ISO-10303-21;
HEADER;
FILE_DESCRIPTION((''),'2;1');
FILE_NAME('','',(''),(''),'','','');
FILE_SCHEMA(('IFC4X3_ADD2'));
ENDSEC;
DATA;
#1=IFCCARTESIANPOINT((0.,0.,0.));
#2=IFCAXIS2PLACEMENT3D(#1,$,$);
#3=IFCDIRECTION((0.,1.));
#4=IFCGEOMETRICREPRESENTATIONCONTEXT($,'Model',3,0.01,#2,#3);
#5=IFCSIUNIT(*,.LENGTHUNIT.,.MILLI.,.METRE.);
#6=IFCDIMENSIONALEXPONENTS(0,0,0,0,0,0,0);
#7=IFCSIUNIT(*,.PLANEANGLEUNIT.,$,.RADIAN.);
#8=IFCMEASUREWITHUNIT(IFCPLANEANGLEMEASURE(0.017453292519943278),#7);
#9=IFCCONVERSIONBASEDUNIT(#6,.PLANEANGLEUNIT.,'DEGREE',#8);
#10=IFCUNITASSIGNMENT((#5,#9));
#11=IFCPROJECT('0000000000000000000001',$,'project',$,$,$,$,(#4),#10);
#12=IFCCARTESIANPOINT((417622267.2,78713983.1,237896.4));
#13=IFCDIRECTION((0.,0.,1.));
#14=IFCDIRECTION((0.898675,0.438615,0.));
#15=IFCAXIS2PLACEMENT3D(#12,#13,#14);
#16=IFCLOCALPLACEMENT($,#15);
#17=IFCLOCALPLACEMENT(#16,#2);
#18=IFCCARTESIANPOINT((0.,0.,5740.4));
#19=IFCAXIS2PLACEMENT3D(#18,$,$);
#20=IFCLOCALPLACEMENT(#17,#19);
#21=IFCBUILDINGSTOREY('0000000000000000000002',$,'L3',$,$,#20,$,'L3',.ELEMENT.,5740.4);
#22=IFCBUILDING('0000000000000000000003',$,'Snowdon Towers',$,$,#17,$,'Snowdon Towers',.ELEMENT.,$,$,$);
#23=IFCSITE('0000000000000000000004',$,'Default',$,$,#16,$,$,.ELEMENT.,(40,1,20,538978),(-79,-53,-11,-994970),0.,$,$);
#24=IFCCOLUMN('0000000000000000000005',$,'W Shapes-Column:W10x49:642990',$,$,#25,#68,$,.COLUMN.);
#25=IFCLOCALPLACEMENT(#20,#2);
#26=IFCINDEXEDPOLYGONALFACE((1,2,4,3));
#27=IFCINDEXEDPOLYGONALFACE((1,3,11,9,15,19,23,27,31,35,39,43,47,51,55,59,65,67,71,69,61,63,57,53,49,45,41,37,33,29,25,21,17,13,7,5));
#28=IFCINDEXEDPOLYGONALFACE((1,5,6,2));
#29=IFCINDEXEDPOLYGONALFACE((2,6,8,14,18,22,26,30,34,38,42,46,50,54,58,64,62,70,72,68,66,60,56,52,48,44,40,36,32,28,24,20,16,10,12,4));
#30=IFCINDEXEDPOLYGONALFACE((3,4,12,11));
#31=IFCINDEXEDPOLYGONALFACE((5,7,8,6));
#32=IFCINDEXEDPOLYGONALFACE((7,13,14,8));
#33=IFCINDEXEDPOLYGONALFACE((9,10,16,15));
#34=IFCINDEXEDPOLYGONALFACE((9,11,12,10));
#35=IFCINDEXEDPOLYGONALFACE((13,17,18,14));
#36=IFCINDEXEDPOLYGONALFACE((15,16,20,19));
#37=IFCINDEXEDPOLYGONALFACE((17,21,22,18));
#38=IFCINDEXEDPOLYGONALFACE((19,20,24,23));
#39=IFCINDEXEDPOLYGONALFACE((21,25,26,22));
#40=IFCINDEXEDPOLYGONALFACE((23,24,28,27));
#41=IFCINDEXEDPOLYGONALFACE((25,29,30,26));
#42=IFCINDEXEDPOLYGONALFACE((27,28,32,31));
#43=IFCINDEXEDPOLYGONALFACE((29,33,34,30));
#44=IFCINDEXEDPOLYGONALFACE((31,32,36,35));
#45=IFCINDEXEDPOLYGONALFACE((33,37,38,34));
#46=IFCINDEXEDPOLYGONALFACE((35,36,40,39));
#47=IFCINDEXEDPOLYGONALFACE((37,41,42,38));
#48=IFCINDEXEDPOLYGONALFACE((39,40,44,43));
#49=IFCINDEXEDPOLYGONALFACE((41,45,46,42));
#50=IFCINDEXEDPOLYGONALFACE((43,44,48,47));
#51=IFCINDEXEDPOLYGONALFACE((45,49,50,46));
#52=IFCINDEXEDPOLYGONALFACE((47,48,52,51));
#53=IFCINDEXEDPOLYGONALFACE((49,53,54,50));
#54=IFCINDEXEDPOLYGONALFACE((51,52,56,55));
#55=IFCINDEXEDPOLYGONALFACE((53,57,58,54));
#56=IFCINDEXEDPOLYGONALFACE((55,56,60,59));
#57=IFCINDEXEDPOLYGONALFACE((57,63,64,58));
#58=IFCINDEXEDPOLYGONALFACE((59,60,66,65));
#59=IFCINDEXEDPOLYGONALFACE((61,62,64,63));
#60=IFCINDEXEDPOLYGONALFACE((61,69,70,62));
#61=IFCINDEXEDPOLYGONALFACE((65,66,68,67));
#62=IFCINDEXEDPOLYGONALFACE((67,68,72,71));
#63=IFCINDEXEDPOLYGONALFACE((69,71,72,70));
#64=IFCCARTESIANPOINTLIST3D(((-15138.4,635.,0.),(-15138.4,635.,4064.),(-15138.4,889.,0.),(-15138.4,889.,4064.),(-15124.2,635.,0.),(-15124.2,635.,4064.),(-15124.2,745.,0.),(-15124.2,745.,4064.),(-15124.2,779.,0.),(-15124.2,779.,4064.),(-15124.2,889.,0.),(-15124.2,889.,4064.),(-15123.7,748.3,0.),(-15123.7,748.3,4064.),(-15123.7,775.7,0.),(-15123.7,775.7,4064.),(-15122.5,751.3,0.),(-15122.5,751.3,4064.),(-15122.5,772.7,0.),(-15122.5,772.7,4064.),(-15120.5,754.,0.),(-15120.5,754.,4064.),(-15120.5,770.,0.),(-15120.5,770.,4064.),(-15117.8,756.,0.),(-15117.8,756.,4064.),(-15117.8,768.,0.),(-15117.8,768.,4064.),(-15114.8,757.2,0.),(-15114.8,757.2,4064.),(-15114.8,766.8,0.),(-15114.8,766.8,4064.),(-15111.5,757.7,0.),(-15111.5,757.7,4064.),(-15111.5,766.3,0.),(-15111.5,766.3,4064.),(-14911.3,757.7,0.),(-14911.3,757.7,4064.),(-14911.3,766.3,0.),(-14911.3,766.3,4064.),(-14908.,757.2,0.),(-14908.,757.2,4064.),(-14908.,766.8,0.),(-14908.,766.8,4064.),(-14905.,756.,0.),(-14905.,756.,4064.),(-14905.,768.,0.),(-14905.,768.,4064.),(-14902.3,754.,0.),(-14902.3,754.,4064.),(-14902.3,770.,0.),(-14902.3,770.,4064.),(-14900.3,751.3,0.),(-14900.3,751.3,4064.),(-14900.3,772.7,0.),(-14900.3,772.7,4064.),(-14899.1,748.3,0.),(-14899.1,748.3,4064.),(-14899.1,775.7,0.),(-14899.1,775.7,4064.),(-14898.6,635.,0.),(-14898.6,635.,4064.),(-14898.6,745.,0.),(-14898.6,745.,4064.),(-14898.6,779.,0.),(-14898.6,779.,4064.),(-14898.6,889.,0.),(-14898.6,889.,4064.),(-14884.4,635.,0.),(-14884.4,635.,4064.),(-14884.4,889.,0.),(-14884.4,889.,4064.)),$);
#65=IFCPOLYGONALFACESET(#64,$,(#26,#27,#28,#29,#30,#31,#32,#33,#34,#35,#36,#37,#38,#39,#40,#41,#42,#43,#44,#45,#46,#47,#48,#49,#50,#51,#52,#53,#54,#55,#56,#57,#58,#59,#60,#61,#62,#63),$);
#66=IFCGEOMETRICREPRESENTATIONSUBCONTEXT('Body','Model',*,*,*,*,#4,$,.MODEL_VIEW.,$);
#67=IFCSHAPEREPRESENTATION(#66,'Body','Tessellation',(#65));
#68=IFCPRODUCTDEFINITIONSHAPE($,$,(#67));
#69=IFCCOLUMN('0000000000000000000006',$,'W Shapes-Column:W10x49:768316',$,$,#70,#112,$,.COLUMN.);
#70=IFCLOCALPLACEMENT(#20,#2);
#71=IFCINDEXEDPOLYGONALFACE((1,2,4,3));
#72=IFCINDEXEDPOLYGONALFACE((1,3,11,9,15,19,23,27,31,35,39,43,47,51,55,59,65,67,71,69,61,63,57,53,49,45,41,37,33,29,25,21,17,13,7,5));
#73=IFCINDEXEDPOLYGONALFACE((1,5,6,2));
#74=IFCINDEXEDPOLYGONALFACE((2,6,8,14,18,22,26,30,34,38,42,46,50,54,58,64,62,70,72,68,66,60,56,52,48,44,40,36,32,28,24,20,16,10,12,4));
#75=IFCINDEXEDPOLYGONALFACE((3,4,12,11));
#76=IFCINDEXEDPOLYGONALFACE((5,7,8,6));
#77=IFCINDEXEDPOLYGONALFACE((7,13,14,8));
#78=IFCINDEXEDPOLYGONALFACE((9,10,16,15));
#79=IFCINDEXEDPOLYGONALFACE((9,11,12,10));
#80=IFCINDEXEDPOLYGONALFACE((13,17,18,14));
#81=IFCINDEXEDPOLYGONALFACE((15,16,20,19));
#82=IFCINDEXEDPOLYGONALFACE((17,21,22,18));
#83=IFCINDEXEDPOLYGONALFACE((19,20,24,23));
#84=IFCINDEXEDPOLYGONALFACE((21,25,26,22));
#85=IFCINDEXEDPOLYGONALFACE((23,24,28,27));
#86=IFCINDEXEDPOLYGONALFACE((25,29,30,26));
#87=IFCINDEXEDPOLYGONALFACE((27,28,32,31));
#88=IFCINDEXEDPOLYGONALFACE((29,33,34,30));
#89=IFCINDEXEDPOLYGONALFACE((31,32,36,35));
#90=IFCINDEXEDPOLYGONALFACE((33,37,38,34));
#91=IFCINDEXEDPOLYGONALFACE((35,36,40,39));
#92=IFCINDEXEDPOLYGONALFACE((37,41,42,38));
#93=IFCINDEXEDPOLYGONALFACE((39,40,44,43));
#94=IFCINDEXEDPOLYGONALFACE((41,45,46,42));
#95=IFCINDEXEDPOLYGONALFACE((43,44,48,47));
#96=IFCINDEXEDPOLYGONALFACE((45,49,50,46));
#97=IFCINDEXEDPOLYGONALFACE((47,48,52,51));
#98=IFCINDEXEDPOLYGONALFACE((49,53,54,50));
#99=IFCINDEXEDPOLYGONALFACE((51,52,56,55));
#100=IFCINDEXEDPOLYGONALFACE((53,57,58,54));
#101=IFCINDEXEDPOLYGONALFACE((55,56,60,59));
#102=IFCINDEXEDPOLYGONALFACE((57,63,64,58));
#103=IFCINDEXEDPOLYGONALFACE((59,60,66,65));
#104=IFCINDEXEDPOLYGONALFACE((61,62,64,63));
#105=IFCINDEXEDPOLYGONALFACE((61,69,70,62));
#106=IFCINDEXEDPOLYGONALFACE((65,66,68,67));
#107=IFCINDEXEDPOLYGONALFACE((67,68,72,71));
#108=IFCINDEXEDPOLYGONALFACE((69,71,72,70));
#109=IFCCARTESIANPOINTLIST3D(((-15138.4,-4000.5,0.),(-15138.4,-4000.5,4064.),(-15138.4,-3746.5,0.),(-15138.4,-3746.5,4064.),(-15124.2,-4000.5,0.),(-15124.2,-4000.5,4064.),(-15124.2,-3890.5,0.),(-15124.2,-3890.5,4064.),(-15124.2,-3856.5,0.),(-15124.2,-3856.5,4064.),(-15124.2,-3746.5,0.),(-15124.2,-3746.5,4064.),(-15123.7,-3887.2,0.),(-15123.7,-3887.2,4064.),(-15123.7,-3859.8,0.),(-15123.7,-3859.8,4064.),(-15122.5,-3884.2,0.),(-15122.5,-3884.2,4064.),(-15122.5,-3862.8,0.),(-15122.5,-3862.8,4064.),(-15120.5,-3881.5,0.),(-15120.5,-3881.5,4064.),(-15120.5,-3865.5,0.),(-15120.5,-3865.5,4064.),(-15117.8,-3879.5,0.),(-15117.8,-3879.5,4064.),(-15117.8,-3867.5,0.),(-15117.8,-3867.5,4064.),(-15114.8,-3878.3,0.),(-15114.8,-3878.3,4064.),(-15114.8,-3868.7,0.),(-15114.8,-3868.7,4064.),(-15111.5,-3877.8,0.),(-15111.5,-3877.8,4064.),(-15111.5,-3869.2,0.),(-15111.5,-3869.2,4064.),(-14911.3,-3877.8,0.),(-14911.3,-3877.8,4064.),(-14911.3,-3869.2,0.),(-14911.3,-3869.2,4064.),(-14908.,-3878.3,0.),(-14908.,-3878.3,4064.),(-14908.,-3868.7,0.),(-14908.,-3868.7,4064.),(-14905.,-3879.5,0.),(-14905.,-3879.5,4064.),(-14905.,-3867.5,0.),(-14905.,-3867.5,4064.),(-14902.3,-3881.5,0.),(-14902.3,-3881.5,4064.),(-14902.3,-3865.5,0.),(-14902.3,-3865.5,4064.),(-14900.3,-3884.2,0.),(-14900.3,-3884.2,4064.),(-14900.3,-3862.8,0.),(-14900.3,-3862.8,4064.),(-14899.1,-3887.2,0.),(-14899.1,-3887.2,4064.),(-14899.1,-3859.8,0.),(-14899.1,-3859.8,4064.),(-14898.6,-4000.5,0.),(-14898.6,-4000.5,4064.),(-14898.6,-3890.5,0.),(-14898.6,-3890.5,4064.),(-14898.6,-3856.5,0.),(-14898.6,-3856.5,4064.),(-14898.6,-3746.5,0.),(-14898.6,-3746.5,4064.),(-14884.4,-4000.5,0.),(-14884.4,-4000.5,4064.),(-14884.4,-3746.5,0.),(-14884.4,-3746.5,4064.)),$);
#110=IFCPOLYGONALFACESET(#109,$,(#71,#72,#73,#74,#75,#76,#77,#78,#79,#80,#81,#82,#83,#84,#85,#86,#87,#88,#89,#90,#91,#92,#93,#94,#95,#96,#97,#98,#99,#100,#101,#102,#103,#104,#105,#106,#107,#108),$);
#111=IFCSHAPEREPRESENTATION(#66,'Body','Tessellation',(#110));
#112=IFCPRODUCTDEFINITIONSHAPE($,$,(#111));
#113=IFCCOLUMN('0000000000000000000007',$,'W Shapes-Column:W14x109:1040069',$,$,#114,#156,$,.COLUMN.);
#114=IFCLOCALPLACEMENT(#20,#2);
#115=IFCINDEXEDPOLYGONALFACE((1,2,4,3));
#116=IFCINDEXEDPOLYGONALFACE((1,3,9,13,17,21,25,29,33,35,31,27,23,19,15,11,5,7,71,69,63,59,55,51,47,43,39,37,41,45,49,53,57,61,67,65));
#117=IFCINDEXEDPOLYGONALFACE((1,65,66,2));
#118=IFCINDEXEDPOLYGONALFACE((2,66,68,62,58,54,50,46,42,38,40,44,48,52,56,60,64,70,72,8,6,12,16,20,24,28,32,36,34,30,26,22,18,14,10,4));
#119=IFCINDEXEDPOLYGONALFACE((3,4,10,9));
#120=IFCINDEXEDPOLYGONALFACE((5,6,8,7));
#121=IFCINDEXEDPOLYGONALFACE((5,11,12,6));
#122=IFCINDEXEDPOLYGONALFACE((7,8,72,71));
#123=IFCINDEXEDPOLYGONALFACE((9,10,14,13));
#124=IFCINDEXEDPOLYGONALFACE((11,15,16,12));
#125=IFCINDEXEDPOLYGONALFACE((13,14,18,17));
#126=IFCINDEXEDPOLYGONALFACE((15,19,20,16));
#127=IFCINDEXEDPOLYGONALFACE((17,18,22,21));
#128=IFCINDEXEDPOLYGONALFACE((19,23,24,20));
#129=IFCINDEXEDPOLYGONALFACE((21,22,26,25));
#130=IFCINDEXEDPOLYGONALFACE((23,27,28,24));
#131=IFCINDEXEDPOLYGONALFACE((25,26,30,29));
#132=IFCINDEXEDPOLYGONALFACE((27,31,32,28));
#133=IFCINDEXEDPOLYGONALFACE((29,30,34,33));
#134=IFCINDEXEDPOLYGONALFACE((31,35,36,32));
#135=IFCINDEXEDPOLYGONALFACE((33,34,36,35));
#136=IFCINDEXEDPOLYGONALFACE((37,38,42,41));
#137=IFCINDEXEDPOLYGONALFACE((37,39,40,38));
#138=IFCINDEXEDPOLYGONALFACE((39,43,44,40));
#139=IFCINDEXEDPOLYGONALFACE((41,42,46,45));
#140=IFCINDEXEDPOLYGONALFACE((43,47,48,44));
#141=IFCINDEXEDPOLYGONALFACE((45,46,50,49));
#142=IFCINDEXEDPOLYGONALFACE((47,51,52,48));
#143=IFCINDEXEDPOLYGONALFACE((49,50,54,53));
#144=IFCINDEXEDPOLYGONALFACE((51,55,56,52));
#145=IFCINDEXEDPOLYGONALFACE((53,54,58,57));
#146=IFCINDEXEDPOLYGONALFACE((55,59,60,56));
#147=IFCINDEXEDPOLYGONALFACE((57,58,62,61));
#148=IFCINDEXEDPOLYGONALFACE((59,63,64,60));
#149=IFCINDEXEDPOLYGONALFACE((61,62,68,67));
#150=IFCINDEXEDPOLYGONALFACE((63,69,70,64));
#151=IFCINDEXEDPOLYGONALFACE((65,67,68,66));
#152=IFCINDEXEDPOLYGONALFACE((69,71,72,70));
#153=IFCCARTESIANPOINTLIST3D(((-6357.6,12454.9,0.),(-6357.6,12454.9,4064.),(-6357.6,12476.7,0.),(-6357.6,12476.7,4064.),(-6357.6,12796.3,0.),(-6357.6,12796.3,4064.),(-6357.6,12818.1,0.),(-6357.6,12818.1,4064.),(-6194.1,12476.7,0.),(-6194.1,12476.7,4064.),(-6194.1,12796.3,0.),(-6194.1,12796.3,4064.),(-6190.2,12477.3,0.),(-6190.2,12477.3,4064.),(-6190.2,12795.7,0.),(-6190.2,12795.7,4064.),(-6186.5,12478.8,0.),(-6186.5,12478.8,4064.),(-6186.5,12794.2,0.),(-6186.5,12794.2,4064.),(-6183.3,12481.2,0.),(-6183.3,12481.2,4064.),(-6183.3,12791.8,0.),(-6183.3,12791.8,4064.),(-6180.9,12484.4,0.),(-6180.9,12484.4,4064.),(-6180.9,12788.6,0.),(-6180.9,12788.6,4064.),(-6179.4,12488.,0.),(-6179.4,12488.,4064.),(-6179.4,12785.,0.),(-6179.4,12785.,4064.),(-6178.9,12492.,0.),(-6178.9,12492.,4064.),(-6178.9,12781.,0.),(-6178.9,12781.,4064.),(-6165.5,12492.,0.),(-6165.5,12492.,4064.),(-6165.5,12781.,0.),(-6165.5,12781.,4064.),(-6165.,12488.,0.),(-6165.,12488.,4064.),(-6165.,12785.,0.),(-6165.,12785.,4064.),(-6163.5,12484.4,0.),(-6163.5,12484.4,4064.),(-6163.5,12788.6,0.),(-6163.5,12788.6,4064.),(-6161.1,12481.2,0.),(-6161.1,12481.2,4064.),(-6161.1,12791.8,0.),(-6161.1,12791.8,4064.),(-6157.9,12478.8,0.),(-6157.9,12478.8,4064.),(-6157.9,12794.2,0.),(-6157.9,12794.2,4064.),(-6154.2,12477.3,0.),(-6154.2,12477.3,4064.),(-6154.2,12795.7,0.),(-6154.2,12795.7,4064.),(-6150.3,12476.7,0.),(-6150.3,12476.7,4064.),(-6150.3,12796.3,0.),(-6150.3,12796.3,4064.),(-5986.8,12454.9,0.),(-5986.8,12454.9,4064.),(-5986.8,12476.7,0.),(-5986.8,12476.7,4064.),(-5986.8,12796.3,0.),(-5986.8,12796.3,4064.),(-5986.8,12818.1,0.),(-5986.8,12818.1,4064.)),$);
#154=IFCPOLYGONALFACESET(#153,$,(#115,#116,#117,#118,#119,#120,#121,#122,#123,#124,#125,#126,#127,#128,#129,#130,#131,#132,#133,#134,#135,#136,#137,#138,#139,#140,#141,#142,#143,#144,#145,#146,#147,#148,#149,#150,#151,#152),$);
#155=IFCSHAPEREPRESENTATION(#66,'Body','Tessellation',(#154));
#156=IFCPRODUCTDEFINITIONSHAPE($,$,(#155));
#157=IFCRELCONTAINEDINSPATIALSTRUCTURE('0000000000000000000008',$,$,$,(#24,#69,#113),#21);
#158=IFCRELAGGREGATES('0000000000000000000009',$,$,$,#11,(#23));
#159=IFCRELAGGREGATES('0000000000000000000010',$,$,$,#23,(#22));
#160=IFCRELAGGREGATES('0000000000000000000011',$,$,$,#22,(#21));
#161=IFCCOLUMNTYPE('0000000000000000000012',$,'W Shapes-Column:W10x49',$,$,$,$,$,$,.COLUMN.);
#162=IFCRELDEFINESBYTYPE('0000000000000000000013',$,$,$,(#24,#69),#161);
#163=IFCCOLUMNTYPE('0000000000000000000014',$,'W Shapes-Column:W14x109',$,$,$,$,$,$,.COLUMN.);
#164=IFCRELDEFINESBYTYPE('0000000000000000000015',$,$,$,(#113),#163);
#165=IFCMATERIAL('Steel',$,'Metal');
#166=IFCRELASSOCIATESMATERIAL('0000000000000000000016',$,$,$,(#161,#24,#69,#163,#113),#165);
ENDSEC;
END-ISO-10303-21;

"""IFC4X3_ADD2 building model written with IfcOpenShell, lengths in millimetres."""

from ifc_helpers import new_model, entity, si_unit, converted_unit, direction, frame, frame_2d, origin, place, context, subcontext, project, spatial, i_section, extrude, source, transform, mapped, material, material_profile, profile_set, profile_usage, type_object, type_shapes, element, save


model = new_model("IFC4X3_ADD2")

# Units and contexts
model_context = context("Model", 3, precision=0.01, world=origin(), true_north=direction((0.0, 1.0)))
body_context = subcontext(model_context, "Body", "Model", "MODEL_VIEW")
ifc_project = project(units=[si_unit("LENGTHUNIT", "METRE", prefix="MILLI"), converted_unit("PLANEANGLEUNIT", "DEGREE", entity("IfcPlaneAngleMeasure", 0.017453292519943278), si_unit("PLANEANGLEUNIT", "RADIAN"), dimensions=[0, 0, 0, 0, 0, 0, 0])], contexts=[model_context])

# Site, building, storey
site_placement = place(None, frame((417622267.2, 78713983.1, 237896.4), z_axis=(0.0, 0.0, 1.0), x_axis=(0.898675, 0.438615, 0.0)))
site = spatial("IfcSite", under=ifc_project, at=site_placement, Name="Default", CompositionType="ELEMENT", RefLatitude=(40, 1, 20, 538978), RefLongitude=(-79, -53, -11, -994970), RefElevation=0.0)
building_placement = place(site_placement, origin())
building = spatial("IfcBuilding", under=site, at=building_placement, Name="Snowdon Towers", LongName="Snowdon Towers", CompositionType="ELEMENT")
storey_placement = place(building_placement, frame((0.0, 0.0, 5740.4)))
storey = spatial("IfcBuildingStorey", under=building, at=storey_placement, Name="L3", LongName="L3", CompositionType="ELEMENT", Elevation=5740.4)

# Columns
ifc_material_1 = material(Name="Steel", Category="Metal")
ifc_material_profile_1 = material_profile(ifc_material_1, i_section(OverallWidth=254.0, OverallDepth=254.0, WebThickness=8.6, FlangeThickness=14.2, FilletRadius=12.7, at=frame_2d((0.0, 0.0), x_axis=(1.0, 0.0))), Name="W10x49")
ifc_profile_set_1 = profile_set([ifc_material_profile_1], Name="W10x49")
ifc_profile_usage_1 = profile_usage(ifc_profile_set_1)
column_type_1 = type_object("IfcColumnType", Name="W Shapes-Column:W10x49", PredefinedType="COLUMN", material=ifc_profile_set_1)
shared_shape_1 = source(origin(), body_context, "Body", "SweptSolid", [
    extrude(i_section(OverallWidth=254.0, OverallDepth=254.0, WebThickness=8.6, FlangeThickness=14.2, FilletRadius=12.7, at=frame_2d((0.0, 0.0), x_axis=(1.0, 0.0))), frame((0.0, 0.0, 5740.4), z_axis=(0.0, 0.0, 1.0), x_axis=(-1.0, 0.0, 0.0)), (0.0, 0.0, 1.0), 4064.0),
])
type_shapes(column_type_1, [shared_shape_1])
for number, where, z_axis, x_axis, name in (
    (1, (-15011.4, 762.0, -5740.4), (0.0, 0.0, 1.0), (0.0, 1.0, 0.0), "W Shapes-Column:W10x49:642990"),
    (2, (-15011.4, -3873.5, -5740.4), (0.0, 0.0, 1.0), (0.0, 1.0, 0.0), "W Shapes-Column:W10x49:768316"),
):
    element("IfcColumn", number, at=place(storey_placement, frame(where, z_axis=z_axis, x_axis=x_axis)), inside=storey, type_object=column_type_1, material=ifc_profile_usage_1, Name=name, PredefinedType="COLUMN", context=body_context, shape_type="MappedRepresentation", body=[
        mapped(shared_shape_1, transform((0.0, 0.0, 0.0), scale=1.0)),
    ])
ifc_material_profile_2 = material_profile(ifc_material_1, i_section(OverallWidth=370.8, OverallDepth=363.2, WebThickness=13.3, FlangeThickness=21.8, FilletRadius=15.2, at=frame_2d((0.0, 0.0), x_axis=(1.0, 0.0))), Name="W14x109")
ifc_profile_set_2 = profile_set([ifc_material_profile_2], Name="W14x109")
ifc_profile_usage_2 = profile_usage(ifc_profile_set_2)
column_type_2 = type_object("IfcColumnType", Name="W Shapes-Column:W14x109", PredefinedType="COLUMN", material=ifc_profile_set_2)
shared_shape_2 = source(origin(), body_context, "Body", "SweptSolid", [
    extrude(i_section(OverallWidth=370.8, OverallDepth=363.2, WebThickness=13.3, FlangeThickness=21.8, FilletRadius=15.2, at=frame_2d((0.0, 0.0), x_axis=(1.0, 0.0))), frame((0.0, 0.0, 5740.4), z_axis=(0.0, 0.0, 1.0), x_axis=(-1.0, 0.0, 0.0)), (0.0, 0.0, 1.0), 4064.0),
])
type_shapes(column_type_2, [shared_shape_2])
column_placement = place(storey_placement, frame((-6172.2, 12636.5, -5740.4), z_axis=(0.0, 0.0, 1.0), x_axis=(-1.0, 0.0, 0.0)))
element("IfcColumn", 3, at=column_placement, inside=storey, type_object=column_type_2, material=ifc_profile_usage_2, Name="W Shapes-Column:W14x109:1040069", PredefinedType="COLUMN", context=body_context, shape_type="MappedRepresentation", body=[
    mapped(shared_shape_2, transform((0.0, 0.0, 0.0), scale=1.0)),
])

save(model, "model.ifc")
